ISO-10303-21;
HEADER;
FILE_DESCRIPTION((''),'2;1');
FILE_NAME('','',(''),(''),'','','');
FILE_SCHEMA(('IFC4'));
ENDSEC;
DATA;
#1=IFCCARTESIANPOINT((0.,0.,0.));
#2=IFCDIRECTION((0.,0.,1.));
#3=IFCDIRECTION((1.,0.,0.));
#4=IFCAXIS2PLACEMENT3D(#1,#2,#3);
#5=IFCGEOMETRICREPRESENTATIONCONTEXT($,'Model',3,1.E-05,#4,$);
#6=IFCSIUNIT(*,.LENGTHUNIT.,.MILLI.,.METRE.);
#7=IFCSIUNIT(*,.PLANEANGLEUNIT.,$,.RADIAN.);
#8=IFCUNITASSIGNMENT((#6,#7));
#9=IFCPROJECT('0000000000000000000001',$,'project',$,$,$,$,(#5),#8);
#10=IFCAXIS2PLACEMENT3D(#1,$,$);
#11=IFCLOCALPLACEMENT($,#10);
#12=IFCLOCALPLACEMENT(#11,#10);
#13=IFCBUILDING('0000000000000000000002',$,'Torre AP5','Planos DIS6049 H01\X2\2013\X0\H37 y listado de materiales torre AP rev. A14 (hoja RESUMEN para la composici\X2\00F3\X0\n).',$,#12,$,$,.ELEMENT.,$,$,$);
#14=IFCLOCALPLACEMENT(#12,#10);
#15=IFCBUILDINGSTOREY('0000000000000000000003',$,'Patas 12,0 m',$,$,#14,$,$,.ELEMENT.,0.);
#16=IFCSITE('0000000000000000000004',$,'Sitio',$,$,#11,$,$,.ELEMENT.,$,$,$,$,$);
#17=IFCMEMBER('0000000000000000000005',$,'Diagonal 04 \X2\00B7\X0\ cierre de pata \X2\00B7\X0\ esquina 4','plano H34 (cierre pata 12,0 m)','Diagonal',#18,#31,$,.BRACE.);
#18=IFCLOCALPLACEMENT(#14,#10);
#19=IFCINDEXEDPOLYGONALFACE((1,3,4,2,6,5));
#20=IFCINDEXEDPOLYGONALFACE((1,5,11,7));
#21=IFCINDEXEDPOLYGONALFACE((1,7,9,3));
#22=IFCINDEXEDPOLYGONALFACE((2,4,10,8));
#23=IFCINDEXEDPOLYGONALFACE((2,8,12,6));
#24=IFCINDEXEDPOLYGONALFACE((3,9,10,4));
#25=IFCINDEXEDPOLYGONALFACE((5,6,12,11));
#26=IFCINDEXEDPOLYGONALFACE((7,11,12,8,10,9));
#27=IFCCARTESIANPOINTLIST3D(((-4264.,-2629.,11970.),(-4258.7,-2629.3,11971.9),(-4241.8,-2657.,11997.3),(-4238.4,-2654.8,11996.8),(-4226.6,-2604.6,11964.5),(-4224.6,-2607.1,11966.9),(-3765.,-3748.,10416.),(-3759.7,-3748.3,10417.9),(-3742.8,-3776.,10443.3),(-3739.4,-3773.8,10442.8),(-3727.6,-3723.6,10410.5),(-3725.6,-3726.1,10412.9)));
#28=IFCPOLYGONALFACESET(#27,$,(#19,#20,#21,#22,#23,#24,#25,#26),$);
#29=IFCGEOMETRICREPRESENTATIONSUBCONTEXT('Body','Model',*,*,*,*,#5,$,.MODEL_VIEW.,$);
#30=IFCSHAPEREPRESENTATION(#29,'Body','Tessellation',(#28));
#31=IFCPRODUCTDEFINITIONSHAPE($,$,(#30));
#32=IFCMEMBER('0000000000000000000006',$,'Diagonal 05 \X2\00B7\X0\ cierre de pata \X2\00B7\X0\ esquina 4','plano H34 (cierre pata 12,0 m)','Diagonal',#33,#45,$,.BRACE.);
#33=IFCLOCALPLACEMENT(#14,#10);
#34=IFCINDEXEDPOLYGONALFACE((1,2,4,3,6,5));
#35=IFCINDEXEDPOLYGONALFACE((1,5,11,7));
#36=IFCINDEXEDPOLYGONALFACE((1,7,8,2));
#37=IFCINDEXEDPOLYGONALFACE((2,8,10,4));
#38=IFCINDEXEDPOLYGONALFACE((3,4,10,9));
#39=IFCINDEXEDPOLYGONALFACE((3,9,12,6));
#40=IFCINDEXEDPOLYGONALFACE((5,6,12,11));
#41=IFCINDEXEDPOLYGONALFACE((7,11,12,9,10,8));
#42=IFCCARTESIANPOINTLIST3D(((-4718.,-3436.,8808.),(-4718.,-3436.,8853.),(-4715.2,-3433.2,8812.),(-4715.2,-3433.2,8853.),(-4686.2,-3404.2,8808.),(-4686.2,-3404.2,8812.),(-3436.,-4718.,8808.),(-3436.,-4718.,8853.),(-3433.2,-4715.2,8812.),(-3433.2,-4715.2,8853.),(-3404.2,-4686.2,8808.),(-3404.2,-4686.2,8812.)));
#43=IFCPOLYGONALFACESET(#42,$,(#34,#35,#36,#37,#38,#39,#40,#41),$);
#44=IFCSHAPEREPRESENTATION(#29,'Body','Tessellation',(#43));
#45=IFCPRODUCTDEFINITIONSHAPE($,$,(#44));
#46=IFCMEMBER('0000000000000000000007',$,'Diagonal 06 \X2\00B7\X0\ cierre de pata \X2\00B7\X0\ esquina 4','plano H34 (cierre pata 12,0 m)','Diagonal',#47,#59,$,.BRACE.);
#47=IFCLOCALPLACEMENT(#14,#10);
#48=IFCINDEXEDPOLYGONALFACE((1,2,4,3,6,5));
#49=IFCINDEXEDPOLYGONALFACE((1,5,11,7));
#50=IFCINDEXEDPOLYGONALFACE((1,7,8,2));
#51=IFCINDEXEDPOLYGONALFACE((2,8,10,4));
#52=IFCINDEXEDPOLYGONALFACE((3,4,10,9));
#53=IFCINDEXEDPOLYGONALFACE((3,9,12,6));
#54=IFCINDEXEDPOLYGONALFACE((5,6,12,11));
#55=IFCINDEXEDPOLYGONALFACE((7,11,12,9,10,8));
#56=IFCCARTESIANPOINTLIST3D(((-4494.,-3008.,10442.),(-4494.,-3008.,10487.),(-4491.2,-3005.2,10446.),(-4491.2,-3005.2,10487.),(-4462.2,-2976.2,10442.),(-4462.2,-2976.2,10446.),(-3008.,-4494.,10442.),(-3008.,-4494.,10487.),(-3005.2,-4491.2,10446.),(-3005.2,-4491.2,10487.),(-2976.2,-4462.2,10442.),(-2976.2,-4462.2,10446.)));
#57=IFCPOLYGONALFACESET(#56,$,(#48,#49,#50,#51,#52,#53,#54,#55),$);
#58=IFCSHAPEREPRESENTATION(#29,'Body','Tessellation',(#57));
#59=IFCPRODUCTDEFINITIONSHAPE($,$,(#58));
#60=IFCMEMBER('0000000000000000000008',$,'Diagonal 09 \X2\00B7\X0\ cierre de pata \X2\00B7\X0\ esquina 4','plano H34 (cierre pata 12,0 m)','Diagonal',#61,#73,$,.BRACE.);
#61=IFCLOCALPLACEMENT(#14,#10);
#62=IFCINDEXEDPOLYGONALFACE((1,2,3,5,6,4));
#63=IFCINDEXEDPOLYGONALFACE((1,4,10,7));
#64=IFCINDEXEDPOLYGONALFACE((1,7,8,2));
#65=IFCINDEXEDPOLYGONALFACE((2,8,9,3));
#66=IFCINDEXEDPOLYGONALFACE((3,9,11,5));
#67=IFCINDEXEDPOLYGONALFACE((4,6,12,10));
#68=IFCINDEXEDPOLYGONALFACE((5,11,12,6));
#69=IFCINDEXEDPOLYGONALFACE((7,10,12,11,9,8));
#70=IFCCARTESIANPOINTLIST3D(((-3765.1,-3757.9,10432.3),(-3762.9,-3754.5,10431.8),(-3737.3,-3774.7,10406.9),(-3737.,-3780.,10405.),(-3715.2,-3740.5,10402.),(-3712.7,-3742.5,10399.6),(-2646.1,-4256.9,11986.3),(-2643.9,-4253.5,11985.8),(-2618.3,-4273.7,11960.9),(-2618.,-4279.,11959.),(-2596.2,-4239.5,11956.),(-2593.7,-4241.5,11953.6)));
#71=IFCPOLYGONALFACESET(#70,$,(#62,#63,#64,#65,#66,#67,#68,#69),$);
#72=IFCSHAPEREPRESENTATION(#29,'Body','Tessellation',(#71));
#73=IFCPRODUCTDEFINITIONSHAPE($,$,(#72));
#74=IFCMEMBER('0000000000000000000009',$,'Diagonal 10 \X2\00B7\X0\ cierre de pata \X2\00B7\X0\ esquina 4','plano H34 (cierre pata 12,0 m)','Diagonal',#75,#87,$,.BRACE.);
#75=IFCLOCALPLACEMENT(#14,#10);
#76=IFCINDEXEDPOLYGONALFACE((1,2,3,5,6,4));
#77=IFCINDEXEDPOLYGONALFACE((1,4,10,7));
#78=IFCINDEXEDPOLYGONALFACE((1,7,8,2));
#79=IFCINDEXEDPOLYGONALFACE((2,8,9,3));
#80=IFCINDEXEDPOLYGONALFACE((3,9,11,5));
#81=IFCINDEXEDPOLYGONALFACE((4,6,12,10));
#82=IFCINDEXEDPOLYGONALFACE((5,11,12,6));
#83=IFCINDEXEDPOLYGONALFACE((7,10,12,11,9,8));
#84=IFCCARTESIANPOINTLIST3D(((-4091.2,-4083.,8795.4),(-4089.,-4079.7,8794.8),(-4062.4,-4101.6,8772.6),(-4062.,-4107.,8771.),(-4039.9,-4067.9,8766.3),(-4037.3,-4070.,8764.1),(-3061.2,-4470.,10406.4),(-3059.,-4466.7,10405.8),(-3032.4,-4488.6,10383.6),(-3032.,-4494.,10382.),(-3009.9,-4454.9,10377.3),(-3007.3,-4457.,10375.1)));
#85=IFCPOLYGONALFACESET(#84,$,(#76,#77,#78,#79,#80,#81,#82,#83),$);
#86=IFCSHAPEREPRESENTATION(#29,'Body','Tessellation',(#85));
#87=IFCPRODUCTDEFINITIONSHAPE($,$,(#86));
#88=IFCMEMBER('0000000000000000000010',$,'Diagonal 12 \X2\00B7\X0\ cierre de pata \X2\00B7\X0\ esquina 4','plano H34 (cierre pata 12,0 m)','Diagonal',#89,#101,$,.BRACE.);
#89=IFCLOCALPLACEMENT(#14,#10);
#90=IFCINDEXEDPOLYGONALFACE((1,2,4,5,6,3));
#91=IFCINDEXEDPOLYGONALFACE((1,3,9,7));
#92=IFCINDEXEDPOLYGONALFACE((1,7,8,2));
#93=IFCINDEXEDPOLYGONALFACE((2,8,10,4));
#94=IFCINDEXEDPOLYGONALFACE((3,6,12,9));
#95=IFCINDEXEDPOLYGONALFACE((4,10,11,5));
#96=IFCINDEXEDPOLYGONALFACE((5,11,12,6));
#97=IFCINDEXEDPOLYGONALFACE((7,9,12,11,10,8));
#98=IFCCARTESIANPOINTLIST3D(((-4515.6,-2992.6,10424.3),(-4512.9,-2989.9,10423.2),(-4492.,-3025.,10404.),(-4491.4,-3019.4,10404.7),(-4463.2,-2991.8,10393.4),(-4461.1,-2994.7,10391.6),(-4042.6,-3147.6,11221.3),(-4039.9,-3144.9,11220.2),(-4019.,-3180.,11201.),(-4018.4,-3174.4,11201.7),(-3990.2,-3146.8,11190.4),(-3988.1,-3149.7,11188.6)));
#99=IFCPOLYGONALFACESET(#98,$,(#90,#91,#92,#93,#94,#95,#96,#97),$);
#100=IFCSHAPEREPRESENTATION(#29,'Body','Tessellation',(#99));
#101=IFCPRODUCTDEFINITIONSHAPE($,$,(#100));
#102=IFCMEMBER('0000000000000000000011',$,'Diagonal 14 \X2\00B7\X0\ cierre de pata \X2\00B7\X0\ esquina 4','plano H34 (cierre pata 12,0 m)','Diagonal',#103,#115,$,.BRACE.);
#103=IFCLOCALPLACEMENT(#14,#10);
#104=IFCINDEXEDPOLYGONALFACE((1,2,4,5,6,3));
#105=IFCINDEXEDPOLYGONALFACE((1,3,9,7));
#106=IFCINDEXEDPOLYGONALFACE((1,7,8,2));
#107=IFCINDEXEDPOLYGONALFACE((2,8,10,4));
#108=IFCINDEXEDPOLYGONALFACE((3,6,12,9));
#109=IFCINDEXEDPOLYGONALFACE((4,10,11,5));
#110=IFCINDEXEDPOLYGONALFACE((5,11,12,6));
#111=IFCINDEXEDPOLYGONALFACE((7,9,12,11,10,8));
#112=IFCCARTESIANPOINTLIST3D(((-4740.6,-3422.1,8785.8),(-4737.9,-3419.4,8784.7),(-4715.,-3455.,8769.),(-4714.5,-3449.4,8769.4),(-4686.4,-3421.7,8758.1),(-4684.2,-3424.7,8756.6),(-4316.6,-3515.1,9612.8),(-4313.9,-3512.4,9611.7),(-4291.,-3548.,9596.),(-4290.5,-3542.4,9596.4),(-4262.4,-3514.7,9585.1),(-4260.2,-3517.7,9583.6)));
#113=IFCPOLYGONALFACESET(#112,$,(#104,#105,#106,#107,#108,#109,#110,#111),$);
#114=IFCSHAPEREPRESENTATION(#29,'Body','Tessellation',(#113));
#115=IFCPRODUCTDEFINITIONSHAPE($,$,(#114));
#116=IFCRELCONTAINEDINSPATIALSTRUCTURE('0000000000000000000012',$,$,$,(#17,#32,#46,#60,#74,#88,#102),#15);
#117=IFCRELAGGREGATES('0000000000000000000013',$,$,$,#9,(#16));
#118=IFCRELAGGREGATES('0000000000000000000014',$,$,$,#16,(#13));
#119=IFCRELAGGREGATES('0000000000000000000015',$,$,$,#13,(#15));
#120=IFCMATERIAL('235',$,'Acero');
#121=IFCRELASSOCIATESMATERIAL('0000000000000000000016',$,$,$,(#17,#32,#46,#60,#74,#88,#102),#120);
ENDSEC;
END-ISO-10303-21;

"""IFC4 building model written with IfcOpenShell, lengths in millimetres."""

from ifc_helpers import new_model, si_unit, frame, frame_2d, origin, origin_with_axes, place, context, subcontext, project, spatial, l_section, extrude, material, element, save


model = new_model("IFC4")

# Units and contexts
model_context = context("Model", 3, precision=1e-05, world=origin_with_axes())
body_context = subcontext(model_context, "Body", "Model", "MODEL_VIEW")
ifc_project = project(units=[si_unit("LENGTHUNIT", "METRE", prefix="MILLI"), si_unit("PLANEANGLEUNIT", "RADIAN")], contexts=[model_context])

# Site, building, storey
site_placement = place(None, origin())
site = spatial("IfcSite", under=ifc_project, at=site_placement, Name="Sitio", CompositionType="ELEMENT")
building_placement = place(site_placement, origin())
building = spatial("IfcBuilding", under=site, at=building_placement, Name="Torre AP5", Description="Planos DIS6049 H01–H37 y listado de materiales torre AP rev. A14 (hoja RESUMEN para la composición).", CompositionType="ELEMENT")
storey_placement = place(building_placement, origin())
storey = spatial("IfcBuildingStorey", under=building, at=storey_placement, Name="Patas 12,0 m", CompositionType="ELEMENT", Elevation=0.0)

# Members
ifc_material_1 = material(Name="235", Category="Acero")
member_1_placement = place(storey_placement, frame((-4264.0, -2629.0, 11970.0), z_axis=(0.252159, -0.565463, -0.785281), x_axis=(0.831906, 0.541208, -0.122581)))
element("IfcMember", 1, at=member_1_placement, inside=storey, material=ifc_material_1, Name="Diagonal 04 · cierre de pata · esquina 4", Description="plano H34 (cierre pata 12,0 m)", ObjectType="Diagonal", PredefinedType="BRACE", context=body_context, shape_type="SweptSolid", body=[
    extrude(l_section(Depth=45.0, Width=45.0, Thickness=4.0, at=frame_2d((22.5, 22.5))), None, (0.0, 0.0, 1.0), 1978.9),
])
member_2_placement = place(storey_placement, frame((-4718.0, -3436.0, 8808.0), z_axis=(0.707107, -0.707107, 0.0), x_axis=(0.707107, 0.707107, 0.0)))
element("IfcMember", 2, at=member_2_placement, inside=storey, material=ifc_material_1, Name="Diagonal 05 · cierre de pata · esquina 4", Description="plano H34 (cierre pata 12,0 m)", ObjectType="Diagonal", PredefinedType="BRACE", context=body_context, shape_type="SweptSolid", body=[
    extrude(l_section(Depth=45.0, Width=45.0, Thickness=4.0, at=frame_2d((22.5, 22.5))), None, (0.0, 0.0, 1.0), 1813.0),
])
member_3_placement = place(storey_placement, frame((-4494.0, -3008.0, 10442.0), z_axis=(0.707107, -0.707107, 0.0), x_axis=(0.707107, 0.707107, 0.0)))
element("IfcMember", 3, at=member_3_placement, inside=storey, material=ifc_material_1, Name="Diagonal 06 · cierre de pata · esquina 4", Description="plano H34 (cierre pata 12,0 m)", ObjectType="Diagonal", PredefinedType="BRACE", context=body_context, shape_type="SweptSolid", body=[
    extrude(l_section(Depth=45.0, Width=45.0, Thickness=4.0, at=frame_2d((22.5, 22.5))), None, (0.0, 0.0, 1.0), 2101.5),
])
member_4_placement = place(storey_placement, frame((-3737.0, -3780.0, 10405.0), z_axis=(0.565463, -0.252159, 0.785281), x_axis=(0.539456, 0.833293, -0.120874)))
element("IfcMember", 4, at=member_4_placement, inside=storey, material=ifc_material_1, Name="Diagonal 09 · cierre de pata · esquina 4", Description="plano H34 (cierre pata 12,0 m)", ObjectType="Diagonal", PredefinedType="BRACE", context=body_context, shape_type="SweptSolid", body=[
    extrude(l_section(Depth=45.0, Width=45.0, Thickness=4.0, at=frame_2d((22.5, 22.5))), None, (0.0, 0.0, 1.0), 1978.9),
])
member_5_placement = place(storey_placement, frame((-4062.0, -4107.0, 8771.0), z_axis=(0.527963, -0.198371, 0.825775), x_axis=(0.548981, 0.821595, -0.153627)))
element("IfcMember", 5, at=member_5_placement, inside=storey, material=ifc_material_1, Name="Diagonal 10 · cierre de pata · esquina 4", Description="plano H34 (cierre pata 12,0 m)", ObjectType="Diagonal", PredefinedType="BRACE", context=body_context, shape_type="SweptSolid", body=[
    extrude(l_section(Depth=45.0, Width=45.0, Thickness=4.0, at=frame_2d((22.5, 22.5))), None, (0.0, 0.0, 1.0), 1950.9),
])
member_6_placement = place(storey_placement, frame((-4492.0, -3025.0, 10404.0), z_axis=(0.503373, -0.164953, 0.848178), x_axis=(0.685914, 0.673253, -0.276139)))
element("IfcMember", 6, at=member_6_placement, inside=storey, material=ifc_material_1, Name="Diagonal 12 · cierre de pata · esquina 4", Description="plano H34 (cierre pata 12,0 m)", ObjectType="Diagonal", PredefinedType="BRACE", context=body_context, shape_type="SweptSolid", body=[
    extrude(l_section(Depth=45.0, Width=45.0, Thickness=4.0, at=frame_2d((22.5, 22.5))), None, (0.0, 0.0, 1.0), 939.7),
])
member_7_placement = place(storey_placement, frame((-4715.0, -3455.0, 8769.0), z_axis=(0.453962, -0.099572, 0.88544), x_axis=(0.685467, 0.673907, -0.275653)))
element("IfcMember", 7, at=member_7_placement, inside=storey, material=ifc_material_1, Name="Diagonal 14 · cierre de pata · esquina 4", Description="plano H34 (cierre pata 12,0 m)", ObjectType="Diagonal", PredefinedType="BRACE", context=body_context, shape_type="SweptSolid", body=[
    extrude(l_section(Depth=45.0, Width=45.0, Thickness=4.0, at=frame_2d((22.5, 22.5))), None, (0.0, 0.0, 1.0), 934.0),
])

save(model, "model.ifc")
